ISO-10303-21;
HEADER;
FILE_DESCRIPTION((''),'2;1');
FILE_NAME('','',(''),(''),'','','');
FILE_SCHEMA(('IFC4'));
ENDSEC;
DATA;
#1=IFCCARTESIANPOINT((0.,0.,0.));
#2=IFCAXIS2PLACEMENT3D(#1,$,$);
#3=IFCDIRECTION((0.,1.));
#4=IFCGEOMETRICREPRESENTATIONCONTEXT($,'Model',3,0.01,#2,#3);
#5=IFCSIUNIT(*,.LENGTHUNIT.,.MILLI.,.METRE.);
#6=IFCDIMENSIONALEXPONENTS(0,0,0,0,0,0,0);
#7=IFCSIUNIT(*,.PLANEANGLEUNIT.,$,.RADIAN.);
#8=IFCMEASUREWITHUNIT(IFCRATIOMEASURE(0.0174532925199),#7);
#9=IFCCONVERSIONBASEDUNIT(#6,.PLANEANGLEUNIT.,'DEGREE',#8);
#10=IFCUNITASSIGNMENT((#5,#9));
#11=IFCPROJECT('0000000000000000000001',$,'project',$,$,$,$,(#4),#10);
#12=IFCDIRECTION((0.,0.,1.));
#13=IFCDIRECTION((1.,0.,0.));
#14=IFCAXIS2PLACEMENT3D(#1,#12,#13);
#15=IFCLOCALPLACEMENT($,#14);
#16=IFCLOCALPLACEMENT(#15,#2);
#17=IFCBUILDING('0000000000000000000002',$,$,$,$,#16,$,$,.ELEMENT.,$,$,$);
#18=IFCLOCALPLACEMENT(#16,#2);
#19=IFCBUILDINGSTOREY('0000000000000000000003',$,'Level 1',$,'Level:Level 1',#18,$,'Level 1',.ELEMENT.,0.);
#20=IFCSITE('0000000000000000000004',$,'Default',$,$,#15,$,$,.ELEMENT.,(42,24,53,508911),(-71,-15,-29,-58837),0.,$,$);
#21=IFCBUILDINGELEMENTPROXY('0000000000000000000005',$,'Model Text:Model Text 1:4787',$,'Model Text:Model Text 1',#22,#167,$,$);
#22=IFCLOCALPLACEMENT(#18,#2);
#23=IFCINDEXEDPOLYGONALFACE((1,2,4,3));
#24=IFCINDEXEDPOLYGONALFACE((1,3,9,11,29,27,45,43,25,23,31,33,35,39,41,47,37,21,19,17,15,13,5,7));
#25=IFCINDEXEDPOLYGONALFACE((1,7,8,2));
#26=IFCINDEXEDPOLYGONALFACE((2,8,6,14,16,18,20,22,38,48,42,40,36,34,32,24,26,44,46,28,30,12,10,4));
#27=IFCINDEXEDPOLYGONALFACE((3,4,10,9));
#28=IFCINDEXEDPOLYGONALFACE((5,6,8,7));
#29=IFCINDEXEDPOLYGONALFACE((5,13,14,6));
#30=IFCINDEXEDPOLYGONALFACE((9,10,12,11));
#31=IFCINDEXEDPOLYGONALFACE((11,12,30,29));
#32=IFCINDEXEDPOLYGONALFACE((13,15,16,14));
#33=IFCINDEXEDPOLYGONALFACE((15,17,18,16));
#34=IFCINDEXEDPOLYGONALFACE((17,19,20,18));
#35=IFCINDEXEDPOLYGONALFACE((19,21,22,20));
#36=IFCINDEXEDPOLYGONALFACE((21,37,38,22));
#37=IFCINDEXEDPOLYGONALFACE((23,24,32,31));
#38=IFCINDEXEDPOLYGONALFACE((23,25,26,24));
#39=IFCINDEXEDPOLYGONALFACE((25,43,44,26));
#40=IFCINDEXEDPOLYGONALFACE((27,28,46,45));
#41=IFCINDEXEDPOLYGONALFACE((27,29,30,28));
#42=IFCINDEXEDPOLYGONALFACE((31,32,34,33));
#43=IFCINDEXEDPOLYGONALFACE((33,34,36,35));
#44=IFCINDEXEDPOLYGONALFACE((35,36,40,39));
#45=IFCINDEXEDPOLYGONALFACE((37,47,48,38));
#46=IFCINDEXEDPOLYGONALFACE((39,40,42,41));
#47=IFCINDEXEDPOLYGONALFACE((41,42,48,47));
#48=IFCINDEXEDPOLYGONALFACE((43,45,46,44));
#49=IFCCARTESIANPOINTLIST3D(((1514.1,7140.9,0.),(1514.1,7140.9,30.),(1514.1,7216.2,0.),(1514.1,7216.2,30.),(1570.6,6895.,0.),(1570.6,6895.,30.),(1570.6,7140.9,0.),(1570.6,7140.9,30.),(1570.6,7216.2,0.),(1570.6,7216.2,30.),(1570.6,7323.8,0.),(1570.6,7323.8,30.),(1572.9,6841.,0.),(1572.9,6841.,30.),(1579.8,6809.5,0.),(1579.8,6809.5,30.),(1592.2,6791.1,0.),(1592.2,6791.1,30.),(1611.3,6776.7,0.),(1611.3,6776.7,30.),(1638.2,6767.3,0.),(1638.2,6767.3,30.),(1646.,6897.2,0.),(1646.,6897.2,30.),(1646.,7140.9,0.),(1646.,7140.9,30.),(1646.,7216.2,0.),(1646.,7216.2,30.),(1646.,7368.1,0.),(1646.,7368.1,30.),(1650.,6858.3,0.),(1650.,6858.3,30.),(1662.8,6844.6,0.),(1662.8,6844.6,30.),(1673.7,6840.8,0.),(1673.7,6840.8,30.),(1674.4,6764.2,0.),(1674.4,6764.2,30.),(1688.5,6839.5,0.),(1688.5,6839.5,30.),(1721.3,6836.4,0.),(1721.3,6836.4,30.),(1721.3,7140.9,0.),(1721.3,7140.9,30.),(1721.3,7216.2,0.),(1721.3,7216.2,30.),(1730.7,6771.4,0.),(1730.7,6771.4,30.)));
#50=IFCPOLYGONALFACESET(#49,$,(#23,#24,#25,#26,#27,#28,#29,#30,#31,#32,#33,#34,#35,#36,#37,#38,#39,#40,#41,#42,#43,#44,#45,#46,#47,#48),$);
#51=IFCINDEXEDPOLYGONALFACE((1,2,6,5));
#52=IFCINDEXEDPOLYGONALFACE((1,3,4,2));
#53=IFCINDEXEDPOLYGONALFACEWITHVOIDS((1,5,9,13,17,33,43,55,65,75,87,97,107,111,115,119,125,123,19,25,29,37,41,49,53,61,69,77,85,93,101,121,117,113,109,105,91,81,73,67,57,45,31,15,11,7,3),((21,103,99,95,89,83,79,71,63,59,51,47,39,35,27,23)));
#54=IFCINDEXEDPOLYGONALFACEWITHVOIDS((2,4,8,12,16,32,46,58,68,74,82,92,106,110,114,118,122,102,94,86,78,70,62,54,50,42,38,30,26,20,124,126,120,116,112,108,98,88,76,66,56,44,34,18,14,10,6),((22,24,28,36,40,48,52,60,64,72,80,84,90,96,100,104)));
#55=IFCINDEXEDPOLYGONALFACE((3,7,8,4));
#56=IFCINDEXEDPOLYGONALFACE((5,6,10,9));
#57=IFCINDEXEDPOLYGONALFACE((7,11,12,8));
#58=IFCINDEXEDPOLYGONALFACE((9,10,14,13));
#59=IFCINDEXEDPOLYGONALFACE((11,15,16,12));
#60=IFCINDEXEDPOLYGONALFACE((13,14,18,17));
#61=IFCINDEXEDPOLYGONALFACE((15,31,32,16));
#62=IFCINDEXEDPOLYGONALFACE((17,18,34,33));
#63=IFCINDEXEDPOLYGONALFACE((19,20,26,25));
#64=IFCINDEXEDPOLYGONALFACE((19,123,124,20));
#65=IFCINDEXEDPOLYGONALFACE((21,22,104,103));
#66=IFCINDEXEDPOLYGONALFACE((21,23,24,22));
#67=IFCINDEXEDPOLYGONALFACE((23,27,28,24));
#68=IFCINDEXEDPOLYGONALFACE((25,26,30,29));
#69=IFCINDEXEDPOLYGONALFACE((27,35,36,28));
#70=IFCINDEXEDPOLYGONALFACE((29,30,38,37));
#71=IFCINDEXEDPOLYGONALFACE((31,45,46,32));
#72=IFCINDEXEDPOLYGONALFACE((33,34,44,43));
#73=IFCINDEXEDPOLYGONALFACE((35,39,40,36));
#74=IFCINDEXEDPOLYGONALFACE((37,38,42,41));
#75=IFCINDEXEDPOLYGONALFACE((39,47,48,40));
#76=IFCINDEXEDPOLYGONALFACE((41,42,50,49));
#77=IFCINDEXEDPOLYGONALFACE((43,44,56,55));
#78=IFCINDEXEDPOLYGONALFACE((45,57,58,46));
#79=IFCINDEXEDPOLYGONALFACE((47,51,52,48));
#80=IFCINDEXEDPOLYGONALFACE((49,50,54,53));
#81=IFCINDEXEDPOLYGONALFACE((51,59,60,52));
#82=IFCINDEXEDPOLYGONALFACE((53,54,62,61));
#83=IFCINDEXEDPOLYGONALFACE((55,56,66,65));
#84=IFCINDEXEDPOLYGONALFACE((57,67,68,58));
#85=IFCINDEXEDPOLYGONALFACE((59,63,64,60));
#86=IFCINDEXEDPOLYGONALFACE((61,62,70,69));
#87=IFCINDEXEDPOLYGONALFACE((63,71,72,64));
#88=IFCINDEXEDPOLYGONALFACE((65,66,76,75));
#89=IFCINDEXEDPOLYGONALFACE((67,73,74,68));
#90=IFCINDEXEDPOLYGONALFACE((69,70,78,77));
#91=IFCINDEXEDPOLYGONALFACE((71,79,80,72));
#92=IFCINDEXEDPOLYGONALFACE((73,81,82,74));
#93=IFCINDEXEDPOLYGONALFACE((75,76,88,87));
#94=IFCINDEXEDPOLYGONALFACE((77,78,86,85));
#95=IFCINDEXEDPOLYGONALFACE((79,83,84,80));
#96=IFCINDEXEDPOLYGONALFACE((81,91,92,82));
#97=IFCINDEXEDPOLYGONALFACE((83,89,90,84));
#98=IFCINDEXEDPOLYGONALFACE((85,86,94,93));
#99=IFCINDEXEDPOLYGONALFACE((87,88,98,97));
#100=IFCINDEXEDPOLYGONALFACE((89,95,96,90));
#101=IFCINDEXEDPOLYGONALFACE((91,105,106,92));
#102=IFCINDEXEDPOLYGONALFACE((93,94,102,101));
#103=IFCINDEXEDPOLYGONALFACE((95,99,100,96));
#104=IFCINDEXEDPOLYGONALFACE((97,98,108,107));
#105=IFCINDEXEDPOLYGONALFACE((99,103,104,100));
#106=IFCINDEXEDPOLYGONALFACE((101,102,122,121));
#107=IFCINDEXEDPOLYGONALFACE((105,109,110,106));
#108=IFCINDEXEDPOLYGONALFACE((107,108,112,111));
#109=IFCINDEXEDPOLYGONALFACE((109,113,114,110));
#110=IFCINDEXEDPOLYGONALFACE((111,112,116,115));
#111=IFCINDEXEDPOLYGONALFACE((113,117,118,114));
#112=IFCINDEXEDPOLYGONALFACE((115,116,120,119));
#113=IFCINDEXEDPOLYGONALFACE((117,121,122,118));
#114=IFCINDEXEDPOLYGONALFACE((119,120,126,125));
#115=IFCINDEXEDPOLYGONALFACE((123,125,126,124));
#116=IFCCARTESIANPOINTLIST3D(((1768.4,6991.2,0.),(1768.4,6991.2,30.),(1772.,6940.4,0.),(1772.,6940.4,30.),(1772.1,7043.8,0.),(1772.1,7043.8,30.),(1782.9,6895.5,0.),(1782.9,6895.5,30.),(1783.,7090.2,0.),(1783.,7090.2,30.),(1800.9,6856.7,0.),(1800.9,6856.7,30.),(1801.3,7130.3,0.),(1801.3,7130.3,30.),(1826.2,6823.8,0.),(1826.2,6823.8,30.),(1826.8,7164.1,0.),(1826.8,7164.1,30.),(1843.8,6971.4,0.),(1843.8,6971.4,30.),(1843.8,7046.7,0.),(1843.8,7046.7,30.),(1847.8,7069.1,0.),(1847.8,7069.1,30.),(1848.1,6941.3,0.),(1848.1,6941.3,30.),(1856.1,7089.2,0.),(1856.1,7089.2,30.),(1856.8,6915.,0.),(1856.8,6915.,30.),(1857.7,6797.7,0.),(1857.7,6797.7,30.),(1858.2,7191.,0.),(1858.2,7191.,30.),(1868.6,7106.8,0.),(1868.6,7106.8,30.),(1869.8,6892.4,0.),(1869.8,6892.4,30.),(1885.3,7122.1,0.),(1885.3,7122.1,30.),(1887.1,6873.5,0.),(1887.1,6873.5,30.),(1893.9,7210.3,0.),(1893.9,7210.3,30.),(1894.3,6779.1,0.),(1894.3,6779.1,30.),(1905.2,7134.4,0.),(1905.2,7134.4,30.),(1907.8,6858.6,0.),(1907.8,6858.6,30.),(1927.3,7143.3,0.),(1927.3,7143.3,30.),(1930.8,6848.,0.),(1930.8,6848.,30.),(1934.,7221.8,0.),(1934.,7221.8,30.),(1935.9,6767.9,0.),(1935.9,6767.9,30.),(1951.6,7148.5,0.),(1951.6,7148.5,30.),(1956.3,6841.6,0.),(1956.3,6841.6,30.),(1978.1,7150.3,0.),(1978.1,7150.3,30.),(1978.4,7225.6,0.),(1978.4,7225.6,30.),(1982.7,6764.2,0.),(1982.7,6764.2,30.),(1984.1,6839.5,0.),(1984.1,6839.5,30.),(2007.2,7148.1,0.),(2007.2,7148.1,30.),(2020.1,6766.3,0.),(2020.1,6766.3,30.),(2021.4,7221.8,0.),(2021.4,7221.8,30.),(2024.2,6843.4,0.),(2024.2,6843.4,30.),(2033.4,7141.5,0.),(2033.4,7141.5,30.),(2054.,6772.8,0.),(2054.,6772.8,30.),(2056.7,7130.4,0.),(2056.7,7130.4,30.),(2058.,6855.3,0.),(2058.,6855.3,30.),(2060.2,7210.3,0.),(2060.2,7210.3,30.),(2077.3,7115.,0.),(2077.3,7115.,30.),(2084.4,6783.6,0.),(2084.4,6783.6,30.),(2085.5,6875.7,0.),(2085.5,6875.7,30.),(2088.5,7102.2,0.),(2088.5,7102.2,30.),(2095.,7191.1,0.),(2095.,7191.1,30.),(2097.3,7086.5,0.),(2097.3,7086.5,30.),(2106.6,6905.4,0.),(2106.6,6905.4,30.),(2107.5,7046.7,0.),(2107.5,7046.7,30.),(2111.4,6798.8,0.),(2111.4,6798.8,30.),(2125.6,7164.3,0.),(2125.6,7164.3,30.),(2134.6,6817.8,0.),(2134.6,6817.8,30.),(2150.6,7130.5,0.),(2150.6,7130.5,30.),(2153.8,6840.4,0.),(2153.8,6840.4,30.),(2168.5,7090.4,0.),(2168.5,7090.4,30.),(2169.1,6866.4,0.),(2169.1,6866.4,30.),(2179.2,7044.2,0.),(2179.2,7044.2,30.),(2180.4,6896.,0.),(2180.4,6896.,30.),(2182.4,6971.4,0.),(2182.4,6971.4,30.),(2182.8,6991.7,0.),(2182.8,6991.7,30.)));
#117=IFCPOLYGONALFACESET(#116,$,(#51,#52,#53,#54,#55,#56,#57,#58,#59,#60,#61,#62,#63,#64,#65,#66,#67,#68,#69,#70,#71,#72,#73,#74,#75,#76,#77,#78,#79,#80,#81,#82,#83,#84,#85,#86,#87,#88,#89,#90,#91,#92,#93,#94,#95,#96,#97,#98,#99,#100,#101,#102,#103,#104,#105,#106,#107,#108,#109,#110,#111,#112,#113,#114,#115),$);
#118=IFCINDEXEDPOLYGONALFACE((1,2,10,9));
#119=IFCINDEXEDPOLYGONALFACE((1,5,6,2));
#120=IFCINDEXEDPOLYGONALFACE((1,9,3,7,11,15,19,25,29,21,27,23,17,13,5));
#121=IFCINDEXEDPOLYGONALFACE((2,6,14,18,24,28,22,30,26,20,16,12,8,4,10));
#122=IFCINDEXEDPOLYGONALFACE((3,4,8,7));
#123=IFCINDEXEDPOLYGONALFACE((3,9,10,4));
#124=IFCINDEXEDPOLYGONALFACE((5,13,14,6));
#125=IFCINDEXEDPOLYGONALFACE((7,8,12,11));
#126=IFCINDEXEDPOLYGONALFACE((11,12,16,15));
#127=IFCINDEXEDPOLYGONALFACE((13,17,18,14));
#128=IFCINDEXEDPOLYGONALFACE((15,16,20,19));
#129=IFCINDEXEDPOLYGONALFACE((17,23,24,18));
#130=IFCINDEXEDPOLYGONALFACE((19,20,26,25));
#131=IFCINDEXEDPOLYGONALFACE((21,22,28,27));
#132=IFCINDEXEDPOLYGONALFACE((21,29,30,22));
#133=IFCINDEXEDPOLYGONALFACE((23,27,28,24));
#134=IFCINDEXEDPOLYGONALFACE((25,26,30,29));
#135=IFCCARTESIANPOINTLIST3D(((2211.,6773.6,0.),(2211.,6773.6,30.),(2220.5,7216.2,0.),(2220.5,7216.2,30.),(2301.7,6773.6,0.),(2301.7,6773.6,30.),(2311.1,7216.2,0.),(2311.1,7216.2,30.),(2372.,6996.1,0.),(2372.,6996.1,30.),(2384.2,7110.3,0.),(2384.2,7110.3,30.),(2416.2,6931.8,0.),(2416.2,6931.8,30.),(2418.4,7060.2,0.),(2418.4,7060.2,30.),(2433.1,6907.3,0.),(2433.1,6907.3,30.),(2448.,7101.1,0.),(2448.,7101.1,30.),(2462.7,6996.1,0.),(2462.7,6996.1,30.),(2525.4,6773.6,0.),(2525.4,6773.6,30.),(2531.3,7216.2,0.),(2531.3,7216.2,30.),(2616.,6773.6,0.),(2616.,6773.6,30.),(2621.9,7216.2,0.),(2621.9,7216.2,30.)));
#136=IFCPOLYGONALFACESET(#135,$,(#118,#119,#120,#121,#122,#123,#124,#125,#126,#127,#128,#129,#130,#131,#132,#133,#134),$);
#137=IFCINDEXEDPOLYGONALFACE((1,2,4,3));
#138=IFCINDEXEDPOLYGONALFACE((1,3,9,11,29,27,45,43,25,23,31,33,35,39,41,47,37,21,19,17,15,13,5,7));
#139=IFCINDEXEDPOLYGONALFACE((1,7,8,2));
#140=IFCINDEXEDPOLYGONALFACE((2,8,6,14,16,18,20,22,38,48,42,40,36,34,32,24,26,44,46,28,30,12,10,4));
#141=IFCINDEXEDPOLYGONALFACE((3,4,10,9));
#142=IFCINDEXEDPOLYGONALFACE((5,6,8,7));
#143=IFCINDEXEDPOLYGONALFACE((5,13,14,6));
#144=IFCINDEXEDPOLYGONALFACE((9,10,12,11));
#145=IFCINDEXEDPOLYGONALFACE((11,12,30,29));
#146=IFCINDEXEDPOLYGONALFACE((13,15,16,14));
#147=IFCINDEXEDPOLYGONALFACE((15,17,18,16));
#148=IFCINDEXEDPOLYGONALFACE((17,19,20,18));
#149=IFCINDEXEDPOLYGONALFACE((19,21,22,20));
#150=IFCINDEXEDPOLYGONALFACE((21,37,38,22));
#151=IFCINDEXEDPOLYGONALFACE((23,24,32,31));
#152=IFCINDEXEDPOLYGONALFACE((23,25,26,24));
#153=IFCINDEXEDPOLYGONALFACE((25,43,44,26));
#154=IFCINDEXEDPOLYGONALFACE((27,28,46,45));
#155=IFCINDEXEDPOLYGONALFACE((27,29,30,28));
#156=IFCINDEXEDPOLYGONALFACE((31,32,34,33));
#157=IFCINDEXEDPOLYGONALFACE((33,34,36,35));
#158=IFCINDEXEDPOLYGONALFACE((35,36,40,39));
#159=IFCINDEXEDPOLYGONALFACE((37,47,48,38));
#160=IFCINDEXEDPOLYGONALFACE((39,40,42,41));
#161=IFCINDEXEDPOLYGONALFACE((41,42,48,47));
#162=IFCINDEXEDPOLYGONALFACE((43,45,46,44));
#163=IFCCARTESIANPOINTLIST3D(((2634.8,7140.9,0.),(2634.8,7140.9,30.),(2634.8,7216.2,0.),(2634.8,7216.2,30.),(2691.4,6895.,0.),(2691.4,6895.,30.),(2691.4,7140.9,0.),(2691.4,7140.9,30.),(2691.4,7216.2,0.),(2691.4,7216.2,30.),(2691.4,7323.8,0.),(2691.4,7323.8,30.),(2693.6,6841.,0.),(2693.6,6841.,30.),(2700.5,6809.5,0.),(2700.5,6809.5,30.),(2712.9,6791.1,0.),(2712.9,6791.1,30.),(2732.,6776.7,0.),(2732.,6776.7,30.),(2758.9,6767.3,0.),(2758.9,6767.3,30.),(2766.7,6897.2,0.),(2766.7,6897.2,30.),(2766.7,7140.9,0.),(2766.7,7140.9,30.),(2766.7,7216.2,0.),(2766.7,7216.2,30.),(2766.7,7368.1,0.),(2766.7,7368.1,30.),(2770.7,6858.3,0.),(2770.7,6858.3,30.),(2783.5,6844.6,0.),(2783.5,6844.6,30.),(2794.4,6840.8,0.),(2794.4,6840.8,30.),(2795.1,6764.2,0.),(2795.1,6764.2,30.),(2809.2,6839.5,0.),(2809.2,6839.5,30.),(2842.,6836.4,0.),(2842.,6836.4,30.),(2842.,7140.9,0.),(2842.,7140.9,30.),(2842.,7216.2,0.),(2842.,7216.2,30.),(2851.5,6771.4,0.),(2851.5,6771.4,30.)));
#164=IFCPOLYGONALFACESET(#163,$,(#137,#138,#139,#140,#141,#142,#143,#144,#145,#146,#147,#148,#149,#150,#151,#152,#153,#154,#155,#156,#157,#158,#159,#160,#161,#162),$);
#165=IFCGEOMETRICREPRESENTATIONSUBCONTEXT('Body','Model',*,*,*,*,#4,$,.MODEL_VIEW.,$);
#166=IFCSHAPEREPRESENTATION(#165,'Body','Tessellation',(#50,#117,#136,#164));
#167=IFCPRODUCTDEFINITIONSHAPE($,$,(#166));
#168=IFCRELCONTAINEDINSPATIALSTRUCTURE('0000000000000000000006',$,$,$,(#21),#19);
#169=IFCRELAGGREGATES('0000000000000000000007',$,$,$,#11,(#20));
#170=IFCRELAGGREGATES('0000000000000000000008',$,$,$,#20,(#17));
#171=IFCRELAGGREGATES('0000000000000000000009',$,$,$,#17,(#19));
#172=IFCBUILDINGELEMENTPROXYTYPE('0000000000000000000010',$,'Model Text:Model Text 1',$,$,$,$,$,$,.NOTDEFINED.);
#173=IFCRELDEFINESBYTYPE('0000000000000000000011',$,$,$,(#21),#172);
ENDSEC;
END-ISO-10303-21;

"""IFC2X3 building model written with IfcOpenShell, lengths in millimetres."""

from ifc_helpers import new_model, entity, si_unit, converted_unit, direction, frame, origin, origin_with_axes, place, context, subcontext, project, spatial, polyline, outline, extrude, type_object, element, save


model = new_model("IFC2X3")

# Units and contexts
model_context = context("Model", 3, precision=0.01, world=origin(), true_north=direction((0.0, 1.0)))
body_context = subcontext(model_context, "Body", "Model", "MODEL_VIEW")
ifc_project = project(units=[si_unit("LENGTHUNIT", "METRE", prefix="MILLI"), converted_unit("PLANEANGLEUNIT", "DEGREE", entity("IfcRatioMeasure", 0.0174532925199), si_unit("PLANEANGLEUNIT", "RADIAN"), dimensions=[0, 0, 0, 0, 0, 0, 0])], contexts=[model_context])

# Site, building, storey
site_placement = place(None, origin_with_axes())
site = spatial("IfcSite", under=ifc_project, at=site_placement, Name="Default", CompositionType="ELEMENT", RefLatitude=(42, 24, 53, 508911), RefLongitude=(-71, -15, -29, -58837), RefElevation=0.0)
building_placement = place(site_placement, origin())
building = spatial("IfcBuilding", under=site, at=building_placement, CompositionType="ELEMENT")
storey_placement = place(building_placement, origin())
storey = spatial("IfcBuildingStorey", under=building, at=storey_placement, Name="Level 1", ObjectType="Level:Level 1", LongName="Level 1", CompositionType="ELEMENT", Elevation=0.0)

# Building element proxy
building_element_proxy_type_1 = type_object("IfcBuildingElementProxyType", Name="Model Text:Model Text 1", PredefinedType="NOTDEFINED")
proxy_1_placement = place(storey_placement, frame((1514.1, 6764.2, 0.0)))
element("IfcBuildingElementProxy", 1, at=proxy_1_placement, inside=storey, type_object=building_element_proxy_type_1, Name="Model Text:Model Text 1:4787", ObjectType="Model Text:Model Text 1", context=body_context, shape_type="SweptSolid", body=[
    extrude(outline(polyline([(-104.4, 140.0), (-71.4, 140.0), (-56.5, 140.1), (-45.4, 137.3), (-31.2, 124.8), (-23.6, 86.5), (-0.8, -156.1), (-75.8, -163.2), (-68.7, -238.2), (6.3, -231.1), (20.5, -382.3), (91.4, -331.1), (81.3, -224.0), (137.5, -218.7), (130.5, -143.7), (74.2, -149.0), (51.2, 95.8), (43.8, 149.3), (34.1, 180.0), (20.0, 197.2), (-0.4, 209.8), (-28.1, 216.6), (-64.4, 216.3), (-119.8, 203.8), (-104.4, 140.0)])), frame((116.4, 221.4, 0.0), z_axis=(0.0, 0.0, 1.0), x_axis=(-0.995595, 0.093756, 0.0)), (0.0, 0.0, 1.0), 30.0),
    extrude(outline(polyline([(-34.3, -135.0), (-69.4, -200.7), (-38.7, -208.6), (-8.6, -211.2), (21.0, -208.6), (49.9, -200.6), (77.9, -187.4), (104.3, -168.9), (129.2, -144.9), (152.6, -115.7), (176.6, -75.4), (191.6, -35.0), (197.5, 5.6), (194.5, 46.4), (182.3, 86.0), (161.1, 123.3), (130.8, 158.1), (91.4, 190.4), (46.4, 217.9), (2.3, 235.8), (-41.0, 244.1), (-83.4, 242.8), (-123.5, 232.8), (-159.9, 214.8), (-192.5, 188.8), (-221.3, 154.8), (-243.0, 117.6), (-256.1, 79.2), (-260.6, 39.8), (-256.4, -0.8), (-243.3, -40.7), (-221.0, -78.5), (-189.5, -114.0), (-148.7, -147.3), (-131.9, -158.7), (64.0, 117.5), (86.0, 96.5), (102.5, 74.2), (113.4, 50.5), (118.7, 25.5), (118.9, 0.1), (114.2, -24.9), (104.7, -49.3), (90.3, -73.3), (63.9, -103.7), (34.7, -124.4), (2.2, -135.0), (-34.3, -135.0)]), holes=[polyline([(2.6, 161.1), (-150.0, -54.0), (-176.6, -22.6), (-184.3, -6.4), (-188.3, 10.1), (-189.0, 35.8), (-184.4, 61.3), (-174.7, 86.5), (-159.7, 111.5), (-142.9, 132.0), (-124.5, 148.8), (-104.6, 161.7), (-83.0, 170.8), (-60.9, 175.6), (-39.2, 175.6), (-18.1, 170.7), (2.6, 161.1)])]), frame((462.5, 191.4, 0.0), z_axis=(0.0, 0.0, -1.0), x_axis=(-0.57866, -0.815569, 0.0)), (0.0, 0.0, -1.0), 30.0),
    extrude(outline(polyline([(-207.2, -230.6), (-116.5, -230.6), (-2.1, -72.4), (14.9, -96.8), (107.1, -230.6), (197.8, -230.6), (44.4, -8.1), (203.7, 212.1), (113.0, 212.1), (29.7, 97.0), (0.2, 56.1), (-34.0, 106.1), (-107.1, 212.1), (-197.8, 212.1), (-46.2, -8.1), (-207.2, -230.6)])), frame((904.1, 240.0, 0.0)), (0.0, 0.0, 1.0), 30.0),
    extrude(outline(polyline([(-104.4, 140.0), (-71.4, 140.0), (-56.5, 140.1), (-45.4, 137.3), (-31.2, 124.8), (-23.6, 86.5), (-0.8, -156.1), (-75.8, -163.2), (-68.7, -238.2), (6.3, -231.1), (20.5, -382.3), (91.4, -331.1), (81.3, -224.0), (137.5, -218.7), (130.5, -143.7), (74.2, -149.0), (51.2, 95.8), (43.8, 149.3), (34.1, 180.0), (20.0, 197.2), (-0.4, 209.8), (-28.1, 216.6), (-64.4, 216.3), (-119.8, 203.8), (-104.4, 140.0)])), frame((1237.1, 221.4, 0.0), z_axis=(0.0, 0.0, 1.0), x_axis=(-0.995595, 0.093756, 0.0)), (0.0, 0.0, 1.0), 30.0),
])

save(model, "model.ifc")
